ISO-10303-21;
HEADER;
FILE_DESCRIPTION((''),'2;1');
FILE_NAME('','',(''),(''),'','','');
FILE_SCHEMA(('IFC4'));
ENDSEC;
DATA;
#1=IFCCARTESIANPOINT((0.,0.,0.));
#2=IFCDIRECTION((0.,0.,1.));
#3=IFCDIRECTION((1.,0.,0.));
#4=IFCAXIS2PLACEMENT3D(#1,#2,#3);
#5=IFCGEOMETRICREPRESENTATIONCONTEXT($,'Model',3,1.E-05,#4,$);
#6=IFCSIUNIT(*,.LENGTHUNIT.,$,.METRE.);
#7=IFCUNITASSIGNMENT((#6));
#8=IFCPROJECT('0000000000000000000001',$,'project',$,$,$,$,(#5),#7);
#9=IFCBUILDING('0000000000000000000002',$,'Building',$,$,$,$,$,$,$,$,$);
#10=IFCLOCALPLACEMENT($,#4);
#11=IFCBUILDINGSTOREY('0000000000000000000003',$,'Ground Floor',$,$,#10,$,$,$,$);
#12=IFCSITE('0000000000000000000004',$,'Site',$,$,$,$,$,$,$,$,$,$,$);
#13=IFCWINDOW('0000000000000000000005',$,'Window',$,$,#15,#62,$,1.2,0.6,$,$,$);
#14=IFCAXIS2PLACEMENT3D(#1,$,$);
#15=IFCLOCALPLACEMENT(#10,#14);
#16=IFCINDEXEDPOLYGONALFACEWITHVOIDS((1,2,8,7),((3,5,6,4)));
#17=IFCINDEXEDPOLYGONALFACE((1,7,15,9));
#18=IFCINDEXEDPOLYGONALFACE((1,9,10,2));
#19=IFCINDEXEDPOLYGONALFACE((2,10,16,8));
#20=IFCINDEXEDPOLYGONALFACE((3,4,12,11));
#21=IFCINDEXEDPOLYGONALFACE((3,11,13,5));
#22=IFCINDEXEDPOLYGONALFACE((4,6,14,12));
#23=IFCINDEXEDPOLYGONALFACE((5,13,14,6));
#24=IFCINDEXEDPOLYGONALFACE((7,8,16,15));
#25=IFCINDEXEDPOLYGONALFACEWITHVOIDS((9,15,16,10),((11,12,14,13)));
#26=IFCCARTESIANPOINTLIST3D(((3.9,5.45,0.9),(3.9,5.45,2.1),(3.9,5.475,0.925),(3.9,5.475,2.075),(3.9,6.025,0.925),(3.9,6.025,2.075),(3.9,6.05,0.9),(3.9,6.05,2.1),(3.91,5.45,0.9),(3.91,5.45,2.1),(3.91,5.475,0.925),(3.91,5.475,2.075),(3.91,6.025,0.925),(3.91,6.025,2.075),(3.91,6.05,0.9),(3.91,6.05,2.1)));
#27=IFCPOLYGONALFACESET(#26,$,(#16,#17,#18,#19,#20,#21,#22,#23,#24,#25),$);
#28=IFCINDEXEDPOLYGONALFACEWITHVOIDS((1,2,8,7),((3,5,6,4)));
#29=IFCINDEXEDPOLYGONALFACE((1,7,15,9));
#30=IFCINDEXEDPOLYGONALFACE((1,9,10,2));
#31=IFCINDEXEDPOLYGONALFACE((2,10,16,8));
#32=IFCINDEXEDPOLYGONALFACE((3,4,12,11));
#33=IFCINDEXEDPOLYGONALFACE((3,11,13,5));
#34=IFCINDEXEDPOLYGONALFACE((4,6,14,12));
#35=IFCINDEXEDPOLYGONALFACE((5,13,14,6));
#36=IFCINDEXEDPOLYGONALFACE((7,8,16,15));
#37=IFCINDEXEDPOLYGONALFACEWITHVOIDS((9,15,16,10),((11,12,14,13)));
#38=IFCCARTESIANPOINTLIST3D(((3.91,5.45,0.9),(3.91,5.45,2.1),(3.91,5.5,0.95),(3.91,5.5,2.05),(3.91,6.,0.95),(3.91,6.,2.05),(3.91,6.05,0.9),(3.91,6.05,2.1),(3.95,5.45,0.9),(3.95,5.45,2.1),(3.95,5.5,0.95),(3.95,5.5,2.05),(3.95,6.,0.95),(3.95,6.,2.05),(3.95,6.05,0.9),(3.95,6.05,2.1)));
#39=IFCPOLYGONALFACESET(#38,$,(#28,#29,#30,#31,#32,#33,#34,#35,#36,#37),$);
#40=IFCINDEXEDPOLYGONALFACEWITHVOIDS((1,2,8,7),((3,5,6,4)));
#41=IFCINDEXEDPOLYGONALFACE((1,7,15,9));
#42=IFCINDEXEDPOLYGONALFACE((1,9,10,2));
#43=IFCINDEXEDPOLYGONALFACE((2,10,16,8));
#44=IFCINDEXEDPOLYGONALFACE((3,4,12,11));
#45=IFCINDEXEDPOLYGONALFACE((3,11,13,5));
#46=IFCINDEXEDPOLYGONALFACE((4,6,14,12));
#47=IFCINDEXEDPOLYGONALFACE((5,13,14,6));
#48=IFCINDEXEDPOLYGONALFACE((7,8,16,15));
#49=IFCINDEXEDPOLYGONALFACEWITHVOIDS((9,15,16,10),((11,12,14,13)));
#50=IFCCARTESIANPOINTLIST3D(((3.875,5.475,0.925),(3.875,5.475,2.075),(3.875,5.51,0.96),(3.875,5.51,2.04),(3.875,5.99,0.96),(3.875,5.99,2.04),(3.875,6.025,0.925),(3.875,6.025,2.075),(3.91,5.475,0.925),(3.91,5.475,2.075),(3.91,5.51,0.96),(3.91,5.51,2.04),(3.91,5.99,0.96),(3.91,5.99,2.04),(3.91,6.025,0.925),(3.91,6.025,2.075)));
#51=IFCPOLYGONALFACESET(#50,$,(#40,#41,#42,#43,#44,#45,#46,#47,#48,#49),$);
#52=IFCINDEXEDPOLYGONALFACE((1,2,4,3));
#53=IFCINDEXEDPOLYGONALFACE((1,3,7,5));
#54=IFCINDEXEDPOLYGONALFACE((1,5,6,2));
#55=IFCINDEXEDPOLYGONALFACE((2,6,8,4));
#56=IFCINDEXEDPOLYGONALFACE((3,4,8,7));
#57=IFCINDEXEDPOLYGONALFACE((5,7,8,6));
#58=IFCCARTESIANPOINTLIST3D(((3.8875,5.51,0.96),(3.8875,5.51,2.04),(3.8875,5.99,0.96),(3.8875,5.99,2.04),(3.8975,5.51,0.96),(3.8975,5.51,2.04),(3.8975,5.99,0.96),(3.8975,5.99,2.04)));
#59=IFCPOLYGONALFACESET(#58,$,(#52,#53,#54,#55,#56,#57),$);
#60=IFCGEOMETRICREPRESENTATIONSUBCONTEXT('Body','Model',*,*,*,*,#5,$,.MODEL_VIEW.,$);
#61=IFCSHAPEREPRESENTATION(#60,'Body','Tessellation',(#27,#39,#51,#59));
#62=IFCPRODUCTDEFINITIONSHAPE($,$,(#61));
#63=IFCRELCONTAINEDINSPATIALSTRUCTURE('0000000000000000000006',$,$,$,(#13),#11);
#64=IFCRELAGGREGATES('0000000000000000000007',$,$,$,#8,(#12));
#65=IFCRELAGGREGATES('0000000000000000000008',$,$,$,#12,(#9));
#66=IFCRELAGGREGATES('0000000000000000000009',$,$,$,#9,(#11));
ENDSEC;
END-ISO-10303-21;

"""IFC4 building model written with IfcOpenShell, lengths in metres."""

from ifc_helpers import new_model, si_unit, frame, origin_with_axes, place, context, subcontext, project, spatial, line, indexed_curve, outline, extrude, element, save


model = new_model("IFC4")

# Units and contexts
model_context = context("Model", 3, precision=1e-05, world=origin_with_axes())
body_context = subcontext(model_context, "Body", "Model", "MODEL_VIEW")
ifc_project = project(units=[si_unit("LENGTHUNIT", "METRE")], contexts=[model_context])

# Site, building, storey
site = spatial("IfcSite", under=ifc_project, Name="Site")
building = spatial("IfcBuilding", under=site, Name="Building")
storey_placement = place(None, origin_with_axes())
storey = spatial("IfcBuildingStorey", under=building, at=storey_placement, Name="Ground Floor")

# Window
window_1_placement = place(storey_placement, frame((4.0, 5.45, 0.9), z_axis=(0.0, 0.0, 1.0), x_axis=(0.0, 1.0, 0.0)))
element("IfcWindow", 1, at=window_1_placement, inside=storey, Name="Window", OverallHeight=1.2, OverallWidth=0.6, context=body_context, shape_type="SweptSolid", body=[
    extrude(outline(indexed_curve([(0.0, 0.0), (0.6, 0.0), (0.6, 1.2), (0.0, 1.2)], segments=[line(1, 2, 3, 4, 1)]), holes=[indexed_curve([(0.025, 0.025), (0.575, 0.025), (0.575, 1.175), (0.025, 1.175)], segments=[line(1, 2, 3, 4, 1)])]), frame((0.0, 0.09, 0.0), z_axis=(0.0, -1.0, 0.0), x_axis=(1.0, 0.0, 0.0)), (0.0, 0.0, -1.0), 0.01),
    extrude(outline(indexed_curve([(0.0, 0.0), (0.6, 0.0), (0.6, 1.2), (0.0, 1.2)], segments=[line(1, 2, 3, 4, 1)]), holes=[indexed_curve([(0.05, 0.05), (0.55, 0.05), (0.55, 1.15), (0.05, 1.15)], segments=[line(1, 2, 3, 4, 1)])]), frame((0.0, 0.05, 0.0), z_axis=(0.0, -1.0, 0.0), x_axis=(1.0, 0.0, 0.0)), (0.0, 0.0, -1.0), 0.04),
    extrude(outline(indexed_curve([(0.0, 0.0), (0.55, 0.0), (0.55, 1.15), (0.0, 1.15)], segments=[line(1, 2, 3, 4, 1)]), holes=[indexed_curve([(0.035, 0.035), (0.515, 0.035), (0.515, 1.115), (0.035, 1.115)], segments=[line(1, 2, 3, 4, 1)])]), frame((0.025, 0.09, 0.025), z_axis=(0.0, -1.0, 0.0), x_axis=(1.0, 0.0, 0.0)), (0.0, 0.0, -1.0), 0.035),
    extrude(outline(indexed_curve([(0.035, 0.035), (0.515, 0.035), (0.515, 1.115), (0.035, 1.115)], segments=[line(1, 2, 3, 4, 1)])), frame((0.025, 0.1025, 0.025), z_axis=(0.0, -1.0, 0.0), x_axis=(1.0, 0.0, 0.0)), (0.0, 0.0, -1.0), 0.01),
])

save(model, "model.ifc")
